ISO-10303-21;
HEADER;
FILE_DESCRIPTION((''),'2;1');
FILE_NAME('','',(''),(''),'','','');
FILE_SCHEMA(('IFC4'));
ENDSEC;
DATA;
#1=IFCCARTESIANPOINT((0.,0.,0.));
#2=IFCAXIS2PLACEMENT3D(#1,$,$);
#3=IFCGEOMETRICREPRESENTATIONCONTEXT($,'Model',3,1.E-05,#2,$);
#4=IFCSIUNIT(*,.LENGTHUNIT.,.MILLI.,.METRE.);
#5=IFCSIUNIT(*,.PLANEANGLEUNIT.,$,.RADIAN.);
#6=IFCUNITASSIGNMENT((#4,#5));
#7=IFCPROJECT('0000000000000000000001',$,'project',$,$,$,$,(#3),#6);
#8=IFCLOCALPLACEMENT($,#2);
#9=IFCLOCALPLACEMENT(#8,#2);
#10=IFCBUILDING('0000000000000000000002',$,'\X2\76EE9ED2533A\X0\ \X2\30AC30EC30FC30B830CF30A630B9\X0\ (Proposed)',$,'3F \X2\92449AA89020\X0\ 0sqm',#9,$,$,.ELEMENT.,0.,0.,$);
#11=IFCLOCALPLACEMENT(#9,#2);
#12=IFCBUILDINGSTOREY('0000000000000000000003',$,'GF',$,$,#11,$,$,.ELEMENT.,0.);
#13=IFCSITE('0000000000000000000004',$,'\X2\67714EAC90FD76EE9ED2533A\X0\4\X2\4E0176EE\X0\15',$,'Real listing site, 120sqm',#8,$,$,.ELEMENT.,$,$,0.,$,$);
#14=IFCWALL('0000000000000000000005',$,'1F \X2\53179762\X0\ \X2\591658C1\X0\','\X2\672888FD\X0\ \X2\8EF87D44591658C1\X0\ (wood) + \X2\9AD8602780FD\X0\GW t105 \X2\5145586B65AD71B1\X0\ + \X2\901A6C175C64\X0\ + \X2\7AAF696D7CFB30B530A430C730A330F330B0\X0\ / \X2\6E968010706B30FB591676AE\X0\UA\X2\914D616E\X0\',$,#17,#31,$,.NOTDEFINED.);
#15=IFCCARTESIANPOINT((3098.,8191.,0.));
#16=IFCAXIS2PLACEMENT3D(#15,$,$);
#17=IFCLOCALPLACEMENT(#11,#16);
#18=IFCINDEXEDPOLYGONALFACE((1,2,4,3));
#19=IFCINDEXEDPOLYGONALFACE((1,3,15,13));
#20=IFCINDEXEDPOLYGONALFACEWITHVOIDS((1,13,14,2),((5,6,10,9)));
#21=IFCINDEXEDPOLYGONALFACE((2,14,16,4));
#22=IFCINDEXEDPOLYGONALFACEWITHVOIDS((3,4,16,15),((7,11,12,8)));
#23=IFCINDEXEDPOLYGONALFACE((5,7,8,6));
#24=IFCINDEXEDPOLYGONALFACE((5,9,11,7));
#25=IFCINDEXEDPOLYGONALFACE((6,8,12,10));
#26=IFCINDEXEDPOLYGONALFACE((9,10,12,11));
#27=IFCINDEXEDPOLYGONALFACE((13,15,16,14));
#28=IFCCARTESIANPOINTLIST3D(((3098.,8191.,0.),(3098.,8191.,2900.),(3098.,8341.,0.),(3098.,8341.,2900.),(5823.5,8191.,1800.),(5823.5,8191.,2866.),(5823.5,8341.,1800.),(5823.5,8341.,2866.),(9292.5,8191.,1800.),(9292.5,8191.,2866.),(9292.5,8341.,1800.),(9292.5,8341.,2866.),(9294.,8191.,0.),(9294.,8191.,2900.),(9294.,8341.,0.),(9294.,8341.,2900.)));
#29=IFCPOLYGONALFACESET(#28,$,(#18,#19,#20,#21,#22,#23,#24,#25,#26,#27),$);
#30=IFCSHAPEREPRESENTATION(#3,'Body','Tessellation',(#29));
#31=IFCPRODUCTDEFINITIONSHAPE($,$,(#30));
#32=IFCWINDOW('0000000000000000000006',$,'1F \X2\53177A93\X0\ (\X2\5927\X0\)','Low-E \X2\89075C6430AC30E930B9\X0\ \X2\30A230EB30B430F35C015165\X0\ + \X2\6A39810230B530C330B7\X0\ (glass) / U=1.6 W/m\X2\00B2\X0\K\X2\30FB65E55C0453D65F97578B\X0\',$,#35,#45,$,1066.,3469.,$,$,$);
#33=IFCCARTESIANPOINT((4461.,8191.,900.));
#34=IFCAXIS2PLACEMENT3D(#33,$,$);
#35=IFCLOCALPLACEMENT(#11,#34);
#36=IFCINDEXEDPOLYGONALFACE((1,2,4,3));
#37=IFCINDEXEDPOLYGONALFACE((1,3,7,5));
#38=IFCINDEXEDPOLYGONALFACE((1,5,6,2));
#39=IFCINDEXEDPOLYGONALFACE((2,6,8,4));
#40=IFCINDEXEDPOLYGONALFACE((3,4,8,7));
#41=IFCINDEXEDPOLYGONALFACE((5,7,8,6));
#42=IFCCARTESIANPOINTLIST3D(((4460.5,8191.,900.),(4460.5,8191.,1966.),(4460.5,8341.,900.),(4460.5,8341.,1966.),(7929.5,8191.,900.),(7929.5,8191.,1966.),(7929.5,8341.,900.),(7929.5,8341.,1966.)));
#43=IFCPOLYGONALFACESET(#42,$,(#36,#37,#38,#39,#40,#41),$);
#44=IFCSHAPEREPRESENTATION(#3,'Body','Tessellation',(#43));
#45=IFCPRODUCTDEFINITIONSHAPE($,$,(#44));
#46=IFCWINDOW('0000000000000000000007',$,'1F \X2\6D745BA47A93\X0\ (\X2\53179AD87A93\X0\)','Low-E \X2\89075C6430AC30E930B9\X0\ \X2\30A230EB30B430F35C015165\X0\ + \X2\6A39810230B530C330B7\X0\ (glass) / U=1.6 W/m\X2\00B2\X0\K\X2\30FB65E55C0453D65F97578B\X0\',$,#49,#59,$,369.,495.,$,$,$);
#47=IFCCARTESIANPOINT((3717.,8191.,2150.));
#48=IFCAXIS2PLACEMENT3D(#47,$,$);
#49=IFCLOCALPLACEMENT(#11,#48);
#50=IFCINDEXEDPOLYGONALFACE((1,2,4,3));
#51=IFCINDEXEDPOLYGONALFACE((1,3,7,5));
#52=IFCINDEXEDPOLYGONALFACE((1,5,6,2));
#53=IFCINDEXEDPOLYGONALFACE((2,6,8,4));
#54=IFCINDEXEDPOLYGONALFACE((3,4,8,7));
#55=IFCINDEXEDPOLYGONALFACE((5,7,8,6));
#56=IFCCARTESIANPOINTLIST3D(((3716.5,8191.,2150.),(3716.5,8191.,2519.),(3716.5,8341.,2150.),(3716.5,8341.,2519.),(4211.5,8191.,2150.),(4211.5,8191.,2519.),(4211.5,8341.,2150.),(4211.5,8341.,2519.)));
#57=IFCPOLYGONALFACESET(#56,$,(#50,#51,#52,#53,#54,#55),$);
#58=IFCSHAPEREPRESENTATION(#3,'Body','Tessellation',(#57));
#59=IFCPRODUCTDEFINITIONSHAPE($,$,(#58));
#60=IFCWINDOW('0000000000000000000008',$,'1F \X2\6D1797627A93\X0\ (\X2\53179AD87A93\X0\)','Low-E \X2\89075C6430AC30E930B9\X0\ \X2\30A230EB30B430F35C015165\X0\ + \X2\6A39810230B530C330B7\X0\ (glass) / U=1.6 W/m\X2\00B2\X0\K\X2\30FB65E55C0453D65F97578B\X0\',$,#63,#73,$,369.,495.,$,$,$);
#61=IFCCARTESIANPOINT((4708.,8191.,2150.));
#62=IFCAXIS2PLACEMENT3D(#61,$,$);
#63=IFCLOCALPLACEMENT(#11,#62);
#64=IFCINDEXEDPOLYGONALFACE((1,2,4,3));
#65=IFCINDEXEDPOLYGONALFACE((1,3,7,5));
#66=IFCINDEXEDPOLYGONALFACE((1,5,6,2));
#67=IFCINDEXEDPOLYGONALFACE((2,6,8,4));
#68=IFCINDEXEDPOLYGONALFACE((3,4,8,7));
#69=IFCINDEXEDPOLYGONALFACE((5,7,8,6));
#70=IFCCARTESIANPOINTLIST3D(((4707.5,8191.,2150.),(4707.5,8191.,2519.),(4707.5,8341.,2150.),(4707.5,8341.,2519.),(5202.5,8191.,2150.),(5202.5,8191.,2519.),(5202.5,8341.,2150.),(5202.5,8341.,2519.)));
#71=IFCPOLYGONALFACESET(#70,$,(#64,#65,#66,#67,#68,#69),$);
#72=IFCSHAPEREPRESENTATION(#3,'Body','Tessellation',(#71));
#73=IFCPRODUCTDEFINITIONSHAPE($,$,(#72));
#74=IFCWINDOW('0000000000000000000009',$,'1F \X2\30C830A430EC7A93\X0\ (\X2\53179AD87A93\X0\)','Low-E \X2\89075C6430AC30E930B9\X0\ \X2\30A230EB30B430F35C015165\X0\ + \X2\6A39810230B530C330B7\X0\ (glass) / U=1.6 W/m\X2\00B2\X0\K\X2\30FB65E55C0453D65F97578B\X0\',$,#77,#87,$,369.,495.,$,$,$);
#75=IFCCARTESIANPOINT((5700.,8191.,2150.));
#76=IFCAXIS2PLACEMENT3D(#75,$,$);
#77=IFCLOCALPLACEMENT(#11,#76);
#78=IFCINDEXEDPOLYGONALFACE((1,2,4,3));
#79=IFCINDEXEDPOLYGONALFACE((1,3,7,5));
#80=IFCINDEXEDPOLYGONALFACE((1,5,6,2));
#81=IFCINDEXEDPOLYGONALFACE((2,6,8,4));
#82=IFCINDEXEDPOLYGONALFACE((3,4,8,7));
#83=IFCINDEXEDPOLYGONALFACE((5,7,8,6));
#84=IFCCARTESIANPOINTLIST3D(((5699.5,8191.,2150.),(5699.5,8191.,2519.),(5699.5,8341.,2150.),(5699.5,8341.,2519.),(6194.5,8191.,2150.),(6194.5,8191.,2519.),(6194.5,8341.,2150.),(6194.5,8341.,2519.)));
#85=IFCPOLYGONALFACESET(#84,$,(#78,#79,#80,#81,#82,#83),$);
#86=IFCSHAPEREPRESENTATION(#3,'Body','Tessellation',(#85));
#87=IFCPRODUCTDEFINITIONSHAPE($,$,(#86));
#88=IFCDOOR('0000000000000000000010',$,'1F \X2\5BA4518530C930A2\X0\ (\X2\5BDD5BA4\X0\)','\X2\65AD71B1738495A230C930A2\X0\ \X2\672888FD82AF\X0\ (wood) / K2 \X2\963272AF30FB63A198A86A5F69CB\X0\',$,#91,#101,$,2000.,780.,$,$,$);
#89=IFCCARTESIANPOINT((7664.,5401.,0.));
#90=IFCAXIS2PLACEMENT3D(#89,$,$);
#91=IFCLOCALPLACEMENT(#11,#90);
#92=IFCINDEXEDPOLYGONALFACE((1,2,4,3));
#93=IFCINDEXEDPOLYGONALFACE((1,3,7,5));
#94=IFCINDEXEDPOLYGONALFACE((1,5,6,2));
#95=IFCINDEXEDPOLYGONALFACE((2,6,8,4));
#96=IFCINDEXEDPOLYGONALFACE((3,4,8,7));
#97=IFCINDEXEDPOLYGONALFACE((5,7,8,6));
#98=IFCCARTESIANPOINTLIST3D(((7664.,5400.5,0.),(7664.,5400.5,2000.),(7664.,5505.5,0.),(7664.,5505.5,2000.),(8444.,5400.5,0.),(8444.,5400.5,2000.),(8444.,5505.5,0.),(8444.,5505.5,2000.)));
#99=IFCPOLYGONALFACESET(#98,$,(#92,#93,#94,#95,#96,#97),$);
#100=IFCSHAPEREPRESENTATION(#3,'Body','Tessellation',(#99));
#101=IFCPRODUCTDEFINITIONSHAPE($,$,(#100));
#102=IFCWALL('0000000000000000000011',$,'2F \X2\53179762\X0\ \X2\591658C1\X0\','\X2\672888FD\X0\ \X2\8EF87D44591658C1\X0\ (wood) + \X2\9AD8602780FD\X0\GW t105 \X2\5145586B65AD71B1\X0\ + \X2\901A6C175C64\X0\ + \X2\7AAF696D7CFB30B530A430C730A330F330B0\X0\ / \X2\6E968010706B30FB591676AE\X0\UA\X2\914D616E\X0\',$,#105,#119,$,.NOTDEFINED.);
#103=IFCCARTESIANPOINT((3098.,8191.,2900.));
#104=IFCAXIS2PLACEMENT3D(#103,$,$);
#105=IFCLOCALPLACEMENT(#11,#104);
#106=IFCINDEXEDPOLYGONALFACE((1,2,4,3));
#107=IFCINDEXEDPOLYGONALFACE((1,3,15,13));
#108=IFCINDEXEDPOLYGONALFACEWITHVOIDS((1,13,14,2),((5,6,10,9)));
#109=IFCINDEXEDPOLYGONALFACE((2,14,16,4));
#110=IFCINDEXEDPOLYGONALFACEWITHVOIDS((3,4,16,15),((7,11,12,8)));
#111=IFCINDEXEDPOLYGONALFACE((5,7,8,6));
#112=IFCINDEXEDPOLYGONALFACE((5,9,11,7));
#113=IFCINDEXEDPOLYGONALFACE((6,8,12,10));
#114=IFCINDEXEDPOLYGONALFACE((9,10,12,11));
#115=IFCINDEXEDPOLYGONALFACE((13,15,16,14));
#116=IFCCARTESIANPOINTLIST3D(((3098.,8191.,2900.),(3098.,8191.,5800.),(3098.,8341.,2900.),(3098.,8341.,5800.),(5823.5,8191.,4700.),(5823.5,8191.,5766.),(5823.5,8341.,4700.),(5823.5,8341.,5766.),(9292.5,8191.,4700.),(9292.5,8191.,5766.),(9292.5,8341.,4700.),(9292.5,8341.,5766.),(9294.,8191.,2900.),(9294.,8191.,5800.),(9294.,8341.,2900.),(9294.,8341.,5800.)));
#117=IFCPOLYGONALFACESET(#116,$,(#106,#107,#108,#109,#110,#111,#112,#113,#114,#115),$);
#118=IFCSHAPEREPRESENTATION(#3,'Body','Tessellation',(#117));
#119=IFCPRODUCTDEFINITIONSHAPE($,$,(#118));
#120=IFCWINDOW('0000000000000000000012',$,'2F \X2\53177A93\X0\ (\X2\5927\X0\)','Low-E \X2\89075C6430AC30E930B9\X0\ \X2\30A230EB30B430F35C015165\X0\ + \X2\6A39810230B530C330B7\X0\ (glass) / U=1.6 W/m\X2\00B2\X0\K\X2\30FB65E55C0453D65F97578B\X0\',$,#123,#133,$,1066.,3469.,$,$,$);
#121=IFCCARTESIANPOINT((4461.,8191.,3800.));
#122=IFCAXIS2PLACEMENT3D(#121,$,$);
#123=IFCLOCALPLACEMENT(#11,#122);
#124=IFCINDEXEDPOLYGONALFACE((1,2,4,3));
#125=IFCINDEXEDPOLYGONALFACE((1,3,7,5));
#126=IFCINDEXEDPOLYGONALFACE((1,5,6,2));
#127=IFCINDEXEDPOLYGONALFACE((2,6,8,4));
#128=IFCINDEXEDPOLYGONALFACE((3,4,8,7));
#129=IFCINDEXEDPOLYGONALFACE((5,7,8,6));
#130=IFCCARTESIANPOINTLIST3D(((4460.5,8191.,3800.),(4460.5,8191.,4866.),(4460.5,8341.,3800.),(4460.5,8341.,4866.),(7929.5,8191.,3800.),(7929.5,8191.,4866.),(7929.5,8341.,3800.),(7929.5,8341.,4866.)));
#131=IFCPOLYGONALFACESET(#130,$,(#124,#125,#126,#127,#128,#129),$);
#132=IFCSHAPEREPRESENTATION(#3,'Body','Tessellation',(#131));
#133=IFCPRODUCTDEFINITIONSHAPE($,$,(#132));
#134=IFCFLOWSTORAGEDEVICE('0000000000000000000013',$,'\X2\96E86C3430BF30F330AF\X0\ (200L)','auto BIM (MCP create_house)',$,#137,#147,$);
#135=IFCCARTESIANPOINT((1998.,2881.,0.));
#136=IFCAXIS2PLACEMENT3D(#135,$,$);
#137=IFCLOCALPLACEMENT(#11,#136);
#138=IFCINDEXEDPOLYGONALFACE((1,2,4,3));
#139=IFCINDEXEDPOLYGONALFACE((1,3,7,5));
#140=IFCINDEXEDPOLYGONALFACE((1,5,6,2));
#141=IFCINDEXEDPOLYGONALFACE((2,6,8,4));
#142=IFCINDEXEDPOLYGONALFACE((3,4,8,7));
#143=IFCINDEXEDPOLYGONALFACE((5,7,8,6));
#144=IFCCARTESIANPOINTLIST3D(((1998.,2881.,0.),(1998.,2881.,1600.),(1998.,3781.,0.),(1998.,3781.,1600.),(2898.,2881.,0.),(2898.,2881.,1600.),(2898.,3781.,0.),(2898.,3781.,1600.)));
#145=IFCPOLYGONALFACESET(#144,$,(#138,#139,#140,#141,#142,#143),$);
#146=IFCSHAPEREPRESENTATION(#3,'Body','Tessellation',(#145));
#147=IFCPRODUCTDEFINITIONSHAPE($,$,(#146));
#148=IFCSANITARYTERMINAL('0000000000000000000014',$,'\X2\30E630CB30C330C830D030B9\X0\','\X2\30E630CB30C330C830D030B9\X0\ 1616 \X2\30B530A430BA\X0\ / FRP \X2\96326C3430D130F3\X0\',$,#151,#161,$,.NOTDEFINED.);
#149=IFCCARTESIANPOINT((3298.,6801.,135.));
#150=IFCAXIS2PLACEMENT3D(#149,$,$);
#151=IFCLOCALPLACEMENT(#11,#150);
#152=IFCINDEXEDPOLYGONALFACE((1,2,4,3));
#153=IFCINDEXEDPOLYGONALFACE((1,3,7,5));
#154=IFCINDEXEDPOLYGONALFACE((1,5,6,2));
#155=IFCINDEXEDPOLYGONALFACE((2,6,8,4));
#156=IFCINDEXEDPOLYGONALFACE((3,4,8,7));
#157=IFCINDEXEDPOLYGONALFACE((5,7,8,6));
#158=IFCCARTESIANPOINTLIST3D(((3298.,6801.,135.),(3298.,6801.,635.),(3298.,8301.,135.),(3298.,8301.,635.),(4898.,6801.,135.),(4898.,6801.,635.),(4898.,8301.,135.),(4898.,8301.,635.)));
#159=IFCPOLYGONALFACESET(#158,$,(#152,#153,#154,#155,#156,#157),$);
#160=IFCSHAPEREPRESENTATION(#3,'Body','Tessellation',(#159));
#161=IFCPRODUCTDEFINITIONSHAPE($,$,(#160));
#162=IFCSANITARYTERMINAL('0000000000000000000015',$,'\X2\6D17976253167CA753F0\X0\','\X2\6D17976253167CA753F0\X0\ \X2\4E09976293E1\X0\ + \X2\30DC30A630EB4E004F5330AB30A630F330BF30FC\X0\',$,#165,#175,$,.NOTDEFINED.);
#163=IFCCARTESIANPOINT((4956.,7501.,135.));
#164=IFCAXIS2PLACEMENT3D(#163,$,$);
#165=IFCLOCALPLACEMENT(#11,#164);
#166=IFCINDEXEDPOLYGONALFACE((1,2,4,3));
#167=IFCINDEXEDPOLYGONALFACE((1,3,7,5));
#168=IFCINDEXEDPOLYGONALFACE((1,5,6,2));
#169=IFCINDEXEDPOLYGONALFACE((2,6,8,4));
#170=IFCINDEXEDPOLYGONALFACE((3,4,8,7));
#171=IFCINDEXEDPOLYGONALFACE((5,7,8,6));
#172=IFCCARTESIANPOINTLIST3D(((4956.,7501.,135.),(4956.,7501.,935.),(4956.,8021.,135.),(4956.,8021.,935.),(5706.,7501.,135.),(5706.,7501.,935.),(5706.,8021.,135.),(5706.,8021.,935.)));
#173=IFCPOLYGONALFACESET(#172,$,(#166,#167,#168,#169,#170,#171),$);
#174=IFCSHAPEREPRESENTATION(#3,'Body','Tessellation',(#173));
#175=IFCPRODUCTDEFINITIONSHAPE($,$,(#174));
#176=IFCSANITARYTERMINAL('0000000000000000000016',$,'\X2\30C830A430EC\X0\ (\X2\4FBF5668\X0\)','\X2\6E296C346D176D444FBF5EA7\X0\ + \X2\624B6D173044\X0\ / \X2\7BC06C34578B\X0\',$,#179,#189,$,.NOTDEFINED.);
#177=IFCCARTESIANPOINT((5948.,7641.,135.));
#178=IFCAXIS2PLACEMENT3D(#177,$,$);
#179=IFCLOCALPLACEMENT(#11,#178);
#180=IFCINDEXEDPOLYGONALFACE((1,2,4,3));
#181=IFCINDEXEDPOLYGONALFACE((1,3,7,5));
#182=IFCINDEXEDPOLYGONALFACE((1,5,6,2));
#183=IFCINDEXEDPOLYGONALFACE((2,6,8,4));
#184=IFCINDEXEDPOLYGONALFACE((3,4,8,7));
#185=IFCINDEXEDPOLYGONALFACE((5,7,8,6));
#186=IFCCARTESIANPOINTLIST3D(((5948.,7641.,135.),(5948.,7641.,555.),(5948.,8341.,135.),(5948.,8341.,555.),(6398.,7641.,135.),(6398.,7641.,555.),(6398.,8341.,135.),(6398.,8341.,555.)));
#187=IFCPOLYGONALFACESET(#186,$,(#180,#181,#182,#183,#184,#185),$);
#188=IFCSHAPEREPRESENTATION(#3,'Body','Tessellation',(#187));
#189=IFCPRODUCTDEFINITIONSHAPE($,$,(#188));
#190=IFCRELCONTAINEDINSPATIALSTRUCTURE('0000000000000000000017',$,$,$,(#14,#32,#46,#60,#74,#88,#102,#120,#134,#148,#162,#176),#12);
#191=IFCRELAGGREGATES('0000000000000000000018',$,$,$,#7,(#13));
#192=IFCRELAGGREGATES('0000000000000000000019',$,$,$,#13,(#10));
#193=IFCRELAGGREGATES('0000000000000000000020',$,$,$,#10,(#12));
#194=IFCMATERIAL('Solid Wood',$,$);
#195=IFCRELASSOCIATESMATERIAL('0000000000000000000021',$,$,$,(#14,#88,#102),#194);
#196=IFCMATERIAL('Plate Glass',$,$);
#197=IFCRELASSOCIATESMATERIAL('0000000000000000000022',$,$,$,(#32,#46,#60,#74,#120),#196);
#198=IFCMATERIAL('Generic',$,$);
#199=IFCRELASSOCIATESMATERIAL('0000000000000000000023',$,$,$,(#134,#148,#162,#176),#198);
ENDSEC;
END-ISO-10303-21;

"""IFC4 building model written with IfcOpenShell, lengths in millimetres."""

from ifc_helpers import new_model, si_unit, frame, frame_2d, origin, place, context, project, spatial, rectangle, extrude, material, element, fill, save


model = new_model("IFC4")

# Units and contexts
model_context = context("Model", 3, precision=1e-05, world=origin())
ifc_project = project(units=[si_unit("LENGTHUNIT", "METRE", prefix="MILLI"), si_unit("PLANEANGLEUNIT", "RADIAN")], contexts=[model_context])

# Site, building, storey
site_placement = place(None, origin())
site = spatial("IfcSite", under=ifc_project, at=site_placement, Name="東京都目黒区4丁目15", ObjectType="Real listing site, 120sqm", CompositionType="ELEMENT", RefElevation=0.0)
building_placement = place(site_placement, origin())
building = spatial("IfcBuilding", under=site, at=building_placement, Name="目黒区 ガレージハウス (Proposed)", ObjectType="3F 鉄骨造 0sqm", CompositionType="ELEMENT", ElevationOfRefHeight=0.0, ElevationOfTerrain=0.0)
storey_placement = place(building_placement, origin())
storey = spatial("IfcBuildingStorey", under=building, at=storey_placement, Name="GF", CompositionType="ELEMENT", Elevation=0.0)

# Wall, openings, windows
ifc_material_1 = material(Name="Solid Wood")
wall_1_placement = place(storey_placement, frame((3098.0, 8191.0, 0.0)))
wall_1 = element("IfcWall", 1, at=wall_1_placement, inside=storey, material=ifc_material_1, Name="1F 北面 外壁", Description="木製 軸組外壁 (wood) + 高性能GW t105 充填断熱 + 通気層 + 窯業系サイディング / 準耐火・外皮UA配慮", PredefinedType="NOTDEFINED", context=model_context, shape_type="SweptSolid", body=[
    extrude(rectangle(XDim=6196.0, YDim=150.0, at=frame_2d((3098.0, 75.0))), frame((3098.0, 8191.0, 0.0)), (0.0, 0.0, 1.0), 2900.0),
])
opening_1_placement = place(storey_placement, frame((4461.0, 8191.0, 900.0)))
opening_1 = element("IfcOpeningElement", 2, at=opening_1_placement, cuts=wall_1, PredefinedType="NOTDEFINED", context=model_context, shape_type="SweptSolid", body=[
    extrude(rectangle(XDim=3469.0, YDim=150.0, at=frame_2d((1734.0, 75.0))), frame((4461.0, 8191.0, 900.0)), (0.0, 0.0, 1.0), 1066.0),
])
opening_2_placement = place(storey_placement, frame((3717.0, 8191.0, 2150.0)))
opening_2 = element("IfcOpeningElement", 3, at=opening_2_placement, cuts=wall_1, PredefinedType="NOTDEFINED", context=model_context, shape_type="SweptSolid", body=[
    extrude(rectangle(XDim=495.0, YDim=150.0, at=frame_2d((247.0, 75.0))), frame((3717.0, 8191.0, 2150.0)), (0.0, 0.0, 1.0), 369.0),
])
opening_3_placement = place(storey_placement, frame((4708.0, 8191.0, 2150.0)))
opening_3 = element("IfcOpeningElement", 4, at=opening_3_placement, cuts=wall_1, PredefinedType="NOTDEFINED", context=model_context, shape_type="SweptSolid", body=[
    extrude(rectangle(XDim=495.0, YDim=150.0, at=frame_2d((247.0, 75.0))), frame((4708.0, 8191.0, 2150.0)), (0.0, 0.0, 1.0), 369.0),
])
opening_4_placement = place(storey_placement, frame((5700.0, 8191.0, 2150.0)))
opening_4 = element("IfcOpeningElement", 5, at=opening_4_placement, cuts=wall_1, PredefinedType="NOTDEFINED", context=model_context, shape_type="SweptSolid", body=[
    extrude(rectangle(XDim=495.0, YDim=150.0, at=frame_2d((247.0, 75.0))), frame((5700.0, 8191.0, 2150.0)), (0.0, 0.0, 1.0), 369.0),
])
ifc_material_2 = material(Name="Plate Glass")
window_1_placement = place(storey_placement, frame((4461.0, 8191.0, 900.0)))
window_1 = element("IfcWindow", 6, at=window_1_placement, inside=storey, material=ifc_material_2, Name="1F 北窓 (大)", Description="Low-E 複層ガラス アルゴン封入 + 樹脂サッシ (glass) / U=1.6 W/m²K・日射取得型", OverallHeight=1066.0, OverallWidth=3469.0, context=model_context, shape_type="SweptSolid", body=[
    extrude(rectangle(XDim=3469.0, YDim=150.0, at=frame_2d((1734.0, 75.0))), frame((4461.0, 8191.0, 900.0)), (0.0, 0.0, 1.0), 1066.0),
])
fill(opening_1, window_1)
window_2_placement = place(storey_placement, frame((3717.0, 8191.0, 2150.0)))
window_2 = element("IfcWindow", 7, at=window_2_placement, inside=storey, material=ifc_material_2, Name="1F 浴室窓 (北高窓)", Description="Low-E 複層ガラス アルゴン封入 + 樹脂サッシ (glass) / U=1.6 W/m²K・日射取得型", OverallHeight=369.0, OverallWidth=495.0, context=model_context, shape_type="SweptSolid", body=[
    extrude(rectangle(XDim=495.0, YDim=150.0, at=frame_2d((247.0, 75.0))), frame((3717.0, 8191.0, 2150.0)), (0.0, 0.0, 1.0), 369.0),
])
fill(opening_2, window_2)
window_3_placement = place(storey_placement, frame((4708.0, 8191.0, 2150.0)))
window_3 = element("IfcWindow", 8, at=window_3_placement, inside=storey, material=ifc_material_2, Name="1F 洗面窓 (北高窓)", Description="Low-E 複層ガラス アルゴン封入 + 樹脂サッシ (glass) / U=1.6 W/m²K・日射取得型", OverallHeight=369.0, OverallWidth=495.0, context=model_context, shape_type="SweptSolid", body=[
    extrude(rectangle(XDim=495.0, YDim=150.0, at=frame_2d((247.0, 75.0))), frame((4708.0, 8191.0, 2150.0)), (0.0, 0.0, 1.0), 369.0),
])
fill(opening_3, window_3)
window_4_placement = place(storey_placement, frame((5700.0, 8191.0, 2150.0)))
window_4 = element("IfcWindow", 9, at=window_4_placement, inside=storey, material=ifc_material_2, Name="1F トイレ窓 (北高窓)", Description="Low-E 複層ガラス アルゴン封入 + 樹脂サッシ (glass) / U=1.6 W/m²K・日射取得型", OverallHeight=369.0, OverallWidth=495.0, context=model_context, shape_type="SweptSolid", body=[
    extrude(rectangle(XDim=495.0, YDim=150.0, at=frame_2d((247.0, 75.0))), frame((5700.0, 8191.0, 2150.0)), (0.0, 0.0, 1.0), 369.0),
])
fill(opening_4, window_4)

# Door
door_1_placement = place(storey_placement, frame((7664.0, 5401.0, 0.0)))
element("IfcDoor", 10, at=door_1_placement, inside=storey, material=ifc_material_1, Name="1F 室内ドア (寝室)", Description="断熱玄関ドア 木製芯 (wood) / K2 防犯・採風機構", OverallHeight=2000.0, OverallWidth=780.0, context=model_context, shape_type="SweptSolid", body=[
    extrude(rectangle(XDim=780.0, YDim=105.0, at=frame_2d((390.0, 52.0))), frame((7664.0, 5401.0, 0.0)), (0.0, 0.0, 1.0), 2000.0),
])

# Wall, opening, window
wall_2_placement = place(storey_placement, frame((3098.0, 8191.0, 2900.0)))
wall_2 = element("IfcWall", 11, at=wall_2_placement, inside=storey, material=ifc_material_1, Name="2F 北面 外壁", Description="木製 軸組外壁 (wood) + 高性能GW t105 充填断熱 + 通気層 + 窯業系サイディング / 準耐火・外皮UA配慮", PredefinedType="NOTDEFINED", context=model_context, shape_type="SweptSolid", body=[
    extrude(rectangle(XDim=6196.0, YDim=150.0, at=frame_2d((3098.0, 75.0))), frame((3098.0, 8191.0, 2900.0)), (0.0, 0.0, 1.0), 2900.0),
])
opening_5_placement = place(storey_placement, frame((4461.0, 8191.0, 3800.0)))
opening_5 = element("IfcOpeningElement", 12, at=opening_5_placement, cuts=wall_2, PredefinedType="NOTDEFINED", context=model_context, shape_type="SweptSolid", body=[
    extrude(rectangle(XDim=3469.0, YDim=150.0, at=frame_2d((1734.0, 75.0))), frame((4461.0, 8191.0, 3800.0)), (0.0, 0.0, 1.0), 1066.0),
])
window_5_placement = place(storey_placement, frame((4461.0, 8191.0, 3800.0)))
window_5 = element("IfcWindow", 13, at=window_5_placement, inside=storey, material=ifc_material_2, Name="2F 北窓 (大)", Description="Low-E 複層ガラス アルゴン封入 + 樹脂サッシ (glass) / U=1.6 W/m²K・日射取得型", OverallHeight=1066.0, OverallWidth=3469.0, context=model_context, shape_type="SweptSolid", body=[
    extrude(rectangle(XDim=3469.0, YDim=150.0, at=frame_2d((1734.0, 75.0))), frame((4461.0, 8191.0, 3800.0)), (0.0, 0.0, 1.0), 1066.0),
])
fill(opening_5, window_5)

# Flow storage device
ifc_material_3 = material(Name="Generic")
flow_storage_device_placement = place(storey_placement, frame((1998.0, 2881.0, 0.0)))
element("IfcFlowStorageDevice", 14, at=flow_storage_device_placement, inside=storey, material=ifc_material_3, Name="雨水タンク (200L)", Description="auto BIM (MCP create_house)", context=model_context, shape_type="SweptSolid", body=[
    extrude(rectangle(XDim=900.0, YDim=900.0, at=frame_2d((450.0, 450.0))), frame((1998.0, 2881.0, 0.0)), (0.0, 0.0, 1.0), 1600.0),
])

# Sanitary terminals
sanitary_terminal_1_placement = place(storey_placement, frame((3298.0, 6801.0, 135.0)))
element("IfcSanitaryTerminal", 15, at=sanitary_terminal_1_placement, inside=storey, material=ifc_material_3, Name="ユニットバス", Description="ユニットバス 1616 サイズ / FRP 防水パン", PredefinedType="NOTDEFINED", context=model_context, shape_type="SweptSolid", body=[
    extrude(rectangle(XDim=1600.0, YDim=1500.0, at=frame_2d((800.0, 750.0))), frame((3298.0, 6801.0, 135.0)), (0.0, 0.0, 1.0), 500.0),
])
sanitary_terminal_2_placement = place(storey_placement, frame((4956.0, 7501.0, 135.0)))
element("IfcSanitaryTerminal", 16, at=sanitary_terminal_2_placement, inside=storey, material=ifc_material_3, Name="洗面化粧台", Description="洗面化粧台 三面鏡 + ボウル一体カウンター", PredefinedType="NOTDEFINED", context=model_context, shape_type="SweptSolid", body=[
    extrude(rectangle(XDim=750.0, YDim=520.0, at=frame_2d((375.0, 260.0))), frame((4956.0, 7501.0, 135.0)), (0.0, 0.0, 1.0), 800.0),
])
sanitary_terminal_3_placement = place(storey_placement, frame((5948.0, 7641.0, 135.0)))
element("IfcSanitaryTerminal", 17, at=sanitary_terminal_3_placement, inside=storey, material=ifc_material_3, Name="トイレ (便器)", Description="温水洗浄便座 + 手洗い / 節水型", PredefinedType="NOTDEFINED", context=model_context, shape_type="SweptSolid", body=[
    extrude(rectangle(XDim=450.0, YDim=700.0, at=frame_2d((225.0, 350.0))), frame((5948.0, 7641.0, 135.0)), (0.0, 0.0, 1.0), 420.0),
])

save(model, "model.ifc")
